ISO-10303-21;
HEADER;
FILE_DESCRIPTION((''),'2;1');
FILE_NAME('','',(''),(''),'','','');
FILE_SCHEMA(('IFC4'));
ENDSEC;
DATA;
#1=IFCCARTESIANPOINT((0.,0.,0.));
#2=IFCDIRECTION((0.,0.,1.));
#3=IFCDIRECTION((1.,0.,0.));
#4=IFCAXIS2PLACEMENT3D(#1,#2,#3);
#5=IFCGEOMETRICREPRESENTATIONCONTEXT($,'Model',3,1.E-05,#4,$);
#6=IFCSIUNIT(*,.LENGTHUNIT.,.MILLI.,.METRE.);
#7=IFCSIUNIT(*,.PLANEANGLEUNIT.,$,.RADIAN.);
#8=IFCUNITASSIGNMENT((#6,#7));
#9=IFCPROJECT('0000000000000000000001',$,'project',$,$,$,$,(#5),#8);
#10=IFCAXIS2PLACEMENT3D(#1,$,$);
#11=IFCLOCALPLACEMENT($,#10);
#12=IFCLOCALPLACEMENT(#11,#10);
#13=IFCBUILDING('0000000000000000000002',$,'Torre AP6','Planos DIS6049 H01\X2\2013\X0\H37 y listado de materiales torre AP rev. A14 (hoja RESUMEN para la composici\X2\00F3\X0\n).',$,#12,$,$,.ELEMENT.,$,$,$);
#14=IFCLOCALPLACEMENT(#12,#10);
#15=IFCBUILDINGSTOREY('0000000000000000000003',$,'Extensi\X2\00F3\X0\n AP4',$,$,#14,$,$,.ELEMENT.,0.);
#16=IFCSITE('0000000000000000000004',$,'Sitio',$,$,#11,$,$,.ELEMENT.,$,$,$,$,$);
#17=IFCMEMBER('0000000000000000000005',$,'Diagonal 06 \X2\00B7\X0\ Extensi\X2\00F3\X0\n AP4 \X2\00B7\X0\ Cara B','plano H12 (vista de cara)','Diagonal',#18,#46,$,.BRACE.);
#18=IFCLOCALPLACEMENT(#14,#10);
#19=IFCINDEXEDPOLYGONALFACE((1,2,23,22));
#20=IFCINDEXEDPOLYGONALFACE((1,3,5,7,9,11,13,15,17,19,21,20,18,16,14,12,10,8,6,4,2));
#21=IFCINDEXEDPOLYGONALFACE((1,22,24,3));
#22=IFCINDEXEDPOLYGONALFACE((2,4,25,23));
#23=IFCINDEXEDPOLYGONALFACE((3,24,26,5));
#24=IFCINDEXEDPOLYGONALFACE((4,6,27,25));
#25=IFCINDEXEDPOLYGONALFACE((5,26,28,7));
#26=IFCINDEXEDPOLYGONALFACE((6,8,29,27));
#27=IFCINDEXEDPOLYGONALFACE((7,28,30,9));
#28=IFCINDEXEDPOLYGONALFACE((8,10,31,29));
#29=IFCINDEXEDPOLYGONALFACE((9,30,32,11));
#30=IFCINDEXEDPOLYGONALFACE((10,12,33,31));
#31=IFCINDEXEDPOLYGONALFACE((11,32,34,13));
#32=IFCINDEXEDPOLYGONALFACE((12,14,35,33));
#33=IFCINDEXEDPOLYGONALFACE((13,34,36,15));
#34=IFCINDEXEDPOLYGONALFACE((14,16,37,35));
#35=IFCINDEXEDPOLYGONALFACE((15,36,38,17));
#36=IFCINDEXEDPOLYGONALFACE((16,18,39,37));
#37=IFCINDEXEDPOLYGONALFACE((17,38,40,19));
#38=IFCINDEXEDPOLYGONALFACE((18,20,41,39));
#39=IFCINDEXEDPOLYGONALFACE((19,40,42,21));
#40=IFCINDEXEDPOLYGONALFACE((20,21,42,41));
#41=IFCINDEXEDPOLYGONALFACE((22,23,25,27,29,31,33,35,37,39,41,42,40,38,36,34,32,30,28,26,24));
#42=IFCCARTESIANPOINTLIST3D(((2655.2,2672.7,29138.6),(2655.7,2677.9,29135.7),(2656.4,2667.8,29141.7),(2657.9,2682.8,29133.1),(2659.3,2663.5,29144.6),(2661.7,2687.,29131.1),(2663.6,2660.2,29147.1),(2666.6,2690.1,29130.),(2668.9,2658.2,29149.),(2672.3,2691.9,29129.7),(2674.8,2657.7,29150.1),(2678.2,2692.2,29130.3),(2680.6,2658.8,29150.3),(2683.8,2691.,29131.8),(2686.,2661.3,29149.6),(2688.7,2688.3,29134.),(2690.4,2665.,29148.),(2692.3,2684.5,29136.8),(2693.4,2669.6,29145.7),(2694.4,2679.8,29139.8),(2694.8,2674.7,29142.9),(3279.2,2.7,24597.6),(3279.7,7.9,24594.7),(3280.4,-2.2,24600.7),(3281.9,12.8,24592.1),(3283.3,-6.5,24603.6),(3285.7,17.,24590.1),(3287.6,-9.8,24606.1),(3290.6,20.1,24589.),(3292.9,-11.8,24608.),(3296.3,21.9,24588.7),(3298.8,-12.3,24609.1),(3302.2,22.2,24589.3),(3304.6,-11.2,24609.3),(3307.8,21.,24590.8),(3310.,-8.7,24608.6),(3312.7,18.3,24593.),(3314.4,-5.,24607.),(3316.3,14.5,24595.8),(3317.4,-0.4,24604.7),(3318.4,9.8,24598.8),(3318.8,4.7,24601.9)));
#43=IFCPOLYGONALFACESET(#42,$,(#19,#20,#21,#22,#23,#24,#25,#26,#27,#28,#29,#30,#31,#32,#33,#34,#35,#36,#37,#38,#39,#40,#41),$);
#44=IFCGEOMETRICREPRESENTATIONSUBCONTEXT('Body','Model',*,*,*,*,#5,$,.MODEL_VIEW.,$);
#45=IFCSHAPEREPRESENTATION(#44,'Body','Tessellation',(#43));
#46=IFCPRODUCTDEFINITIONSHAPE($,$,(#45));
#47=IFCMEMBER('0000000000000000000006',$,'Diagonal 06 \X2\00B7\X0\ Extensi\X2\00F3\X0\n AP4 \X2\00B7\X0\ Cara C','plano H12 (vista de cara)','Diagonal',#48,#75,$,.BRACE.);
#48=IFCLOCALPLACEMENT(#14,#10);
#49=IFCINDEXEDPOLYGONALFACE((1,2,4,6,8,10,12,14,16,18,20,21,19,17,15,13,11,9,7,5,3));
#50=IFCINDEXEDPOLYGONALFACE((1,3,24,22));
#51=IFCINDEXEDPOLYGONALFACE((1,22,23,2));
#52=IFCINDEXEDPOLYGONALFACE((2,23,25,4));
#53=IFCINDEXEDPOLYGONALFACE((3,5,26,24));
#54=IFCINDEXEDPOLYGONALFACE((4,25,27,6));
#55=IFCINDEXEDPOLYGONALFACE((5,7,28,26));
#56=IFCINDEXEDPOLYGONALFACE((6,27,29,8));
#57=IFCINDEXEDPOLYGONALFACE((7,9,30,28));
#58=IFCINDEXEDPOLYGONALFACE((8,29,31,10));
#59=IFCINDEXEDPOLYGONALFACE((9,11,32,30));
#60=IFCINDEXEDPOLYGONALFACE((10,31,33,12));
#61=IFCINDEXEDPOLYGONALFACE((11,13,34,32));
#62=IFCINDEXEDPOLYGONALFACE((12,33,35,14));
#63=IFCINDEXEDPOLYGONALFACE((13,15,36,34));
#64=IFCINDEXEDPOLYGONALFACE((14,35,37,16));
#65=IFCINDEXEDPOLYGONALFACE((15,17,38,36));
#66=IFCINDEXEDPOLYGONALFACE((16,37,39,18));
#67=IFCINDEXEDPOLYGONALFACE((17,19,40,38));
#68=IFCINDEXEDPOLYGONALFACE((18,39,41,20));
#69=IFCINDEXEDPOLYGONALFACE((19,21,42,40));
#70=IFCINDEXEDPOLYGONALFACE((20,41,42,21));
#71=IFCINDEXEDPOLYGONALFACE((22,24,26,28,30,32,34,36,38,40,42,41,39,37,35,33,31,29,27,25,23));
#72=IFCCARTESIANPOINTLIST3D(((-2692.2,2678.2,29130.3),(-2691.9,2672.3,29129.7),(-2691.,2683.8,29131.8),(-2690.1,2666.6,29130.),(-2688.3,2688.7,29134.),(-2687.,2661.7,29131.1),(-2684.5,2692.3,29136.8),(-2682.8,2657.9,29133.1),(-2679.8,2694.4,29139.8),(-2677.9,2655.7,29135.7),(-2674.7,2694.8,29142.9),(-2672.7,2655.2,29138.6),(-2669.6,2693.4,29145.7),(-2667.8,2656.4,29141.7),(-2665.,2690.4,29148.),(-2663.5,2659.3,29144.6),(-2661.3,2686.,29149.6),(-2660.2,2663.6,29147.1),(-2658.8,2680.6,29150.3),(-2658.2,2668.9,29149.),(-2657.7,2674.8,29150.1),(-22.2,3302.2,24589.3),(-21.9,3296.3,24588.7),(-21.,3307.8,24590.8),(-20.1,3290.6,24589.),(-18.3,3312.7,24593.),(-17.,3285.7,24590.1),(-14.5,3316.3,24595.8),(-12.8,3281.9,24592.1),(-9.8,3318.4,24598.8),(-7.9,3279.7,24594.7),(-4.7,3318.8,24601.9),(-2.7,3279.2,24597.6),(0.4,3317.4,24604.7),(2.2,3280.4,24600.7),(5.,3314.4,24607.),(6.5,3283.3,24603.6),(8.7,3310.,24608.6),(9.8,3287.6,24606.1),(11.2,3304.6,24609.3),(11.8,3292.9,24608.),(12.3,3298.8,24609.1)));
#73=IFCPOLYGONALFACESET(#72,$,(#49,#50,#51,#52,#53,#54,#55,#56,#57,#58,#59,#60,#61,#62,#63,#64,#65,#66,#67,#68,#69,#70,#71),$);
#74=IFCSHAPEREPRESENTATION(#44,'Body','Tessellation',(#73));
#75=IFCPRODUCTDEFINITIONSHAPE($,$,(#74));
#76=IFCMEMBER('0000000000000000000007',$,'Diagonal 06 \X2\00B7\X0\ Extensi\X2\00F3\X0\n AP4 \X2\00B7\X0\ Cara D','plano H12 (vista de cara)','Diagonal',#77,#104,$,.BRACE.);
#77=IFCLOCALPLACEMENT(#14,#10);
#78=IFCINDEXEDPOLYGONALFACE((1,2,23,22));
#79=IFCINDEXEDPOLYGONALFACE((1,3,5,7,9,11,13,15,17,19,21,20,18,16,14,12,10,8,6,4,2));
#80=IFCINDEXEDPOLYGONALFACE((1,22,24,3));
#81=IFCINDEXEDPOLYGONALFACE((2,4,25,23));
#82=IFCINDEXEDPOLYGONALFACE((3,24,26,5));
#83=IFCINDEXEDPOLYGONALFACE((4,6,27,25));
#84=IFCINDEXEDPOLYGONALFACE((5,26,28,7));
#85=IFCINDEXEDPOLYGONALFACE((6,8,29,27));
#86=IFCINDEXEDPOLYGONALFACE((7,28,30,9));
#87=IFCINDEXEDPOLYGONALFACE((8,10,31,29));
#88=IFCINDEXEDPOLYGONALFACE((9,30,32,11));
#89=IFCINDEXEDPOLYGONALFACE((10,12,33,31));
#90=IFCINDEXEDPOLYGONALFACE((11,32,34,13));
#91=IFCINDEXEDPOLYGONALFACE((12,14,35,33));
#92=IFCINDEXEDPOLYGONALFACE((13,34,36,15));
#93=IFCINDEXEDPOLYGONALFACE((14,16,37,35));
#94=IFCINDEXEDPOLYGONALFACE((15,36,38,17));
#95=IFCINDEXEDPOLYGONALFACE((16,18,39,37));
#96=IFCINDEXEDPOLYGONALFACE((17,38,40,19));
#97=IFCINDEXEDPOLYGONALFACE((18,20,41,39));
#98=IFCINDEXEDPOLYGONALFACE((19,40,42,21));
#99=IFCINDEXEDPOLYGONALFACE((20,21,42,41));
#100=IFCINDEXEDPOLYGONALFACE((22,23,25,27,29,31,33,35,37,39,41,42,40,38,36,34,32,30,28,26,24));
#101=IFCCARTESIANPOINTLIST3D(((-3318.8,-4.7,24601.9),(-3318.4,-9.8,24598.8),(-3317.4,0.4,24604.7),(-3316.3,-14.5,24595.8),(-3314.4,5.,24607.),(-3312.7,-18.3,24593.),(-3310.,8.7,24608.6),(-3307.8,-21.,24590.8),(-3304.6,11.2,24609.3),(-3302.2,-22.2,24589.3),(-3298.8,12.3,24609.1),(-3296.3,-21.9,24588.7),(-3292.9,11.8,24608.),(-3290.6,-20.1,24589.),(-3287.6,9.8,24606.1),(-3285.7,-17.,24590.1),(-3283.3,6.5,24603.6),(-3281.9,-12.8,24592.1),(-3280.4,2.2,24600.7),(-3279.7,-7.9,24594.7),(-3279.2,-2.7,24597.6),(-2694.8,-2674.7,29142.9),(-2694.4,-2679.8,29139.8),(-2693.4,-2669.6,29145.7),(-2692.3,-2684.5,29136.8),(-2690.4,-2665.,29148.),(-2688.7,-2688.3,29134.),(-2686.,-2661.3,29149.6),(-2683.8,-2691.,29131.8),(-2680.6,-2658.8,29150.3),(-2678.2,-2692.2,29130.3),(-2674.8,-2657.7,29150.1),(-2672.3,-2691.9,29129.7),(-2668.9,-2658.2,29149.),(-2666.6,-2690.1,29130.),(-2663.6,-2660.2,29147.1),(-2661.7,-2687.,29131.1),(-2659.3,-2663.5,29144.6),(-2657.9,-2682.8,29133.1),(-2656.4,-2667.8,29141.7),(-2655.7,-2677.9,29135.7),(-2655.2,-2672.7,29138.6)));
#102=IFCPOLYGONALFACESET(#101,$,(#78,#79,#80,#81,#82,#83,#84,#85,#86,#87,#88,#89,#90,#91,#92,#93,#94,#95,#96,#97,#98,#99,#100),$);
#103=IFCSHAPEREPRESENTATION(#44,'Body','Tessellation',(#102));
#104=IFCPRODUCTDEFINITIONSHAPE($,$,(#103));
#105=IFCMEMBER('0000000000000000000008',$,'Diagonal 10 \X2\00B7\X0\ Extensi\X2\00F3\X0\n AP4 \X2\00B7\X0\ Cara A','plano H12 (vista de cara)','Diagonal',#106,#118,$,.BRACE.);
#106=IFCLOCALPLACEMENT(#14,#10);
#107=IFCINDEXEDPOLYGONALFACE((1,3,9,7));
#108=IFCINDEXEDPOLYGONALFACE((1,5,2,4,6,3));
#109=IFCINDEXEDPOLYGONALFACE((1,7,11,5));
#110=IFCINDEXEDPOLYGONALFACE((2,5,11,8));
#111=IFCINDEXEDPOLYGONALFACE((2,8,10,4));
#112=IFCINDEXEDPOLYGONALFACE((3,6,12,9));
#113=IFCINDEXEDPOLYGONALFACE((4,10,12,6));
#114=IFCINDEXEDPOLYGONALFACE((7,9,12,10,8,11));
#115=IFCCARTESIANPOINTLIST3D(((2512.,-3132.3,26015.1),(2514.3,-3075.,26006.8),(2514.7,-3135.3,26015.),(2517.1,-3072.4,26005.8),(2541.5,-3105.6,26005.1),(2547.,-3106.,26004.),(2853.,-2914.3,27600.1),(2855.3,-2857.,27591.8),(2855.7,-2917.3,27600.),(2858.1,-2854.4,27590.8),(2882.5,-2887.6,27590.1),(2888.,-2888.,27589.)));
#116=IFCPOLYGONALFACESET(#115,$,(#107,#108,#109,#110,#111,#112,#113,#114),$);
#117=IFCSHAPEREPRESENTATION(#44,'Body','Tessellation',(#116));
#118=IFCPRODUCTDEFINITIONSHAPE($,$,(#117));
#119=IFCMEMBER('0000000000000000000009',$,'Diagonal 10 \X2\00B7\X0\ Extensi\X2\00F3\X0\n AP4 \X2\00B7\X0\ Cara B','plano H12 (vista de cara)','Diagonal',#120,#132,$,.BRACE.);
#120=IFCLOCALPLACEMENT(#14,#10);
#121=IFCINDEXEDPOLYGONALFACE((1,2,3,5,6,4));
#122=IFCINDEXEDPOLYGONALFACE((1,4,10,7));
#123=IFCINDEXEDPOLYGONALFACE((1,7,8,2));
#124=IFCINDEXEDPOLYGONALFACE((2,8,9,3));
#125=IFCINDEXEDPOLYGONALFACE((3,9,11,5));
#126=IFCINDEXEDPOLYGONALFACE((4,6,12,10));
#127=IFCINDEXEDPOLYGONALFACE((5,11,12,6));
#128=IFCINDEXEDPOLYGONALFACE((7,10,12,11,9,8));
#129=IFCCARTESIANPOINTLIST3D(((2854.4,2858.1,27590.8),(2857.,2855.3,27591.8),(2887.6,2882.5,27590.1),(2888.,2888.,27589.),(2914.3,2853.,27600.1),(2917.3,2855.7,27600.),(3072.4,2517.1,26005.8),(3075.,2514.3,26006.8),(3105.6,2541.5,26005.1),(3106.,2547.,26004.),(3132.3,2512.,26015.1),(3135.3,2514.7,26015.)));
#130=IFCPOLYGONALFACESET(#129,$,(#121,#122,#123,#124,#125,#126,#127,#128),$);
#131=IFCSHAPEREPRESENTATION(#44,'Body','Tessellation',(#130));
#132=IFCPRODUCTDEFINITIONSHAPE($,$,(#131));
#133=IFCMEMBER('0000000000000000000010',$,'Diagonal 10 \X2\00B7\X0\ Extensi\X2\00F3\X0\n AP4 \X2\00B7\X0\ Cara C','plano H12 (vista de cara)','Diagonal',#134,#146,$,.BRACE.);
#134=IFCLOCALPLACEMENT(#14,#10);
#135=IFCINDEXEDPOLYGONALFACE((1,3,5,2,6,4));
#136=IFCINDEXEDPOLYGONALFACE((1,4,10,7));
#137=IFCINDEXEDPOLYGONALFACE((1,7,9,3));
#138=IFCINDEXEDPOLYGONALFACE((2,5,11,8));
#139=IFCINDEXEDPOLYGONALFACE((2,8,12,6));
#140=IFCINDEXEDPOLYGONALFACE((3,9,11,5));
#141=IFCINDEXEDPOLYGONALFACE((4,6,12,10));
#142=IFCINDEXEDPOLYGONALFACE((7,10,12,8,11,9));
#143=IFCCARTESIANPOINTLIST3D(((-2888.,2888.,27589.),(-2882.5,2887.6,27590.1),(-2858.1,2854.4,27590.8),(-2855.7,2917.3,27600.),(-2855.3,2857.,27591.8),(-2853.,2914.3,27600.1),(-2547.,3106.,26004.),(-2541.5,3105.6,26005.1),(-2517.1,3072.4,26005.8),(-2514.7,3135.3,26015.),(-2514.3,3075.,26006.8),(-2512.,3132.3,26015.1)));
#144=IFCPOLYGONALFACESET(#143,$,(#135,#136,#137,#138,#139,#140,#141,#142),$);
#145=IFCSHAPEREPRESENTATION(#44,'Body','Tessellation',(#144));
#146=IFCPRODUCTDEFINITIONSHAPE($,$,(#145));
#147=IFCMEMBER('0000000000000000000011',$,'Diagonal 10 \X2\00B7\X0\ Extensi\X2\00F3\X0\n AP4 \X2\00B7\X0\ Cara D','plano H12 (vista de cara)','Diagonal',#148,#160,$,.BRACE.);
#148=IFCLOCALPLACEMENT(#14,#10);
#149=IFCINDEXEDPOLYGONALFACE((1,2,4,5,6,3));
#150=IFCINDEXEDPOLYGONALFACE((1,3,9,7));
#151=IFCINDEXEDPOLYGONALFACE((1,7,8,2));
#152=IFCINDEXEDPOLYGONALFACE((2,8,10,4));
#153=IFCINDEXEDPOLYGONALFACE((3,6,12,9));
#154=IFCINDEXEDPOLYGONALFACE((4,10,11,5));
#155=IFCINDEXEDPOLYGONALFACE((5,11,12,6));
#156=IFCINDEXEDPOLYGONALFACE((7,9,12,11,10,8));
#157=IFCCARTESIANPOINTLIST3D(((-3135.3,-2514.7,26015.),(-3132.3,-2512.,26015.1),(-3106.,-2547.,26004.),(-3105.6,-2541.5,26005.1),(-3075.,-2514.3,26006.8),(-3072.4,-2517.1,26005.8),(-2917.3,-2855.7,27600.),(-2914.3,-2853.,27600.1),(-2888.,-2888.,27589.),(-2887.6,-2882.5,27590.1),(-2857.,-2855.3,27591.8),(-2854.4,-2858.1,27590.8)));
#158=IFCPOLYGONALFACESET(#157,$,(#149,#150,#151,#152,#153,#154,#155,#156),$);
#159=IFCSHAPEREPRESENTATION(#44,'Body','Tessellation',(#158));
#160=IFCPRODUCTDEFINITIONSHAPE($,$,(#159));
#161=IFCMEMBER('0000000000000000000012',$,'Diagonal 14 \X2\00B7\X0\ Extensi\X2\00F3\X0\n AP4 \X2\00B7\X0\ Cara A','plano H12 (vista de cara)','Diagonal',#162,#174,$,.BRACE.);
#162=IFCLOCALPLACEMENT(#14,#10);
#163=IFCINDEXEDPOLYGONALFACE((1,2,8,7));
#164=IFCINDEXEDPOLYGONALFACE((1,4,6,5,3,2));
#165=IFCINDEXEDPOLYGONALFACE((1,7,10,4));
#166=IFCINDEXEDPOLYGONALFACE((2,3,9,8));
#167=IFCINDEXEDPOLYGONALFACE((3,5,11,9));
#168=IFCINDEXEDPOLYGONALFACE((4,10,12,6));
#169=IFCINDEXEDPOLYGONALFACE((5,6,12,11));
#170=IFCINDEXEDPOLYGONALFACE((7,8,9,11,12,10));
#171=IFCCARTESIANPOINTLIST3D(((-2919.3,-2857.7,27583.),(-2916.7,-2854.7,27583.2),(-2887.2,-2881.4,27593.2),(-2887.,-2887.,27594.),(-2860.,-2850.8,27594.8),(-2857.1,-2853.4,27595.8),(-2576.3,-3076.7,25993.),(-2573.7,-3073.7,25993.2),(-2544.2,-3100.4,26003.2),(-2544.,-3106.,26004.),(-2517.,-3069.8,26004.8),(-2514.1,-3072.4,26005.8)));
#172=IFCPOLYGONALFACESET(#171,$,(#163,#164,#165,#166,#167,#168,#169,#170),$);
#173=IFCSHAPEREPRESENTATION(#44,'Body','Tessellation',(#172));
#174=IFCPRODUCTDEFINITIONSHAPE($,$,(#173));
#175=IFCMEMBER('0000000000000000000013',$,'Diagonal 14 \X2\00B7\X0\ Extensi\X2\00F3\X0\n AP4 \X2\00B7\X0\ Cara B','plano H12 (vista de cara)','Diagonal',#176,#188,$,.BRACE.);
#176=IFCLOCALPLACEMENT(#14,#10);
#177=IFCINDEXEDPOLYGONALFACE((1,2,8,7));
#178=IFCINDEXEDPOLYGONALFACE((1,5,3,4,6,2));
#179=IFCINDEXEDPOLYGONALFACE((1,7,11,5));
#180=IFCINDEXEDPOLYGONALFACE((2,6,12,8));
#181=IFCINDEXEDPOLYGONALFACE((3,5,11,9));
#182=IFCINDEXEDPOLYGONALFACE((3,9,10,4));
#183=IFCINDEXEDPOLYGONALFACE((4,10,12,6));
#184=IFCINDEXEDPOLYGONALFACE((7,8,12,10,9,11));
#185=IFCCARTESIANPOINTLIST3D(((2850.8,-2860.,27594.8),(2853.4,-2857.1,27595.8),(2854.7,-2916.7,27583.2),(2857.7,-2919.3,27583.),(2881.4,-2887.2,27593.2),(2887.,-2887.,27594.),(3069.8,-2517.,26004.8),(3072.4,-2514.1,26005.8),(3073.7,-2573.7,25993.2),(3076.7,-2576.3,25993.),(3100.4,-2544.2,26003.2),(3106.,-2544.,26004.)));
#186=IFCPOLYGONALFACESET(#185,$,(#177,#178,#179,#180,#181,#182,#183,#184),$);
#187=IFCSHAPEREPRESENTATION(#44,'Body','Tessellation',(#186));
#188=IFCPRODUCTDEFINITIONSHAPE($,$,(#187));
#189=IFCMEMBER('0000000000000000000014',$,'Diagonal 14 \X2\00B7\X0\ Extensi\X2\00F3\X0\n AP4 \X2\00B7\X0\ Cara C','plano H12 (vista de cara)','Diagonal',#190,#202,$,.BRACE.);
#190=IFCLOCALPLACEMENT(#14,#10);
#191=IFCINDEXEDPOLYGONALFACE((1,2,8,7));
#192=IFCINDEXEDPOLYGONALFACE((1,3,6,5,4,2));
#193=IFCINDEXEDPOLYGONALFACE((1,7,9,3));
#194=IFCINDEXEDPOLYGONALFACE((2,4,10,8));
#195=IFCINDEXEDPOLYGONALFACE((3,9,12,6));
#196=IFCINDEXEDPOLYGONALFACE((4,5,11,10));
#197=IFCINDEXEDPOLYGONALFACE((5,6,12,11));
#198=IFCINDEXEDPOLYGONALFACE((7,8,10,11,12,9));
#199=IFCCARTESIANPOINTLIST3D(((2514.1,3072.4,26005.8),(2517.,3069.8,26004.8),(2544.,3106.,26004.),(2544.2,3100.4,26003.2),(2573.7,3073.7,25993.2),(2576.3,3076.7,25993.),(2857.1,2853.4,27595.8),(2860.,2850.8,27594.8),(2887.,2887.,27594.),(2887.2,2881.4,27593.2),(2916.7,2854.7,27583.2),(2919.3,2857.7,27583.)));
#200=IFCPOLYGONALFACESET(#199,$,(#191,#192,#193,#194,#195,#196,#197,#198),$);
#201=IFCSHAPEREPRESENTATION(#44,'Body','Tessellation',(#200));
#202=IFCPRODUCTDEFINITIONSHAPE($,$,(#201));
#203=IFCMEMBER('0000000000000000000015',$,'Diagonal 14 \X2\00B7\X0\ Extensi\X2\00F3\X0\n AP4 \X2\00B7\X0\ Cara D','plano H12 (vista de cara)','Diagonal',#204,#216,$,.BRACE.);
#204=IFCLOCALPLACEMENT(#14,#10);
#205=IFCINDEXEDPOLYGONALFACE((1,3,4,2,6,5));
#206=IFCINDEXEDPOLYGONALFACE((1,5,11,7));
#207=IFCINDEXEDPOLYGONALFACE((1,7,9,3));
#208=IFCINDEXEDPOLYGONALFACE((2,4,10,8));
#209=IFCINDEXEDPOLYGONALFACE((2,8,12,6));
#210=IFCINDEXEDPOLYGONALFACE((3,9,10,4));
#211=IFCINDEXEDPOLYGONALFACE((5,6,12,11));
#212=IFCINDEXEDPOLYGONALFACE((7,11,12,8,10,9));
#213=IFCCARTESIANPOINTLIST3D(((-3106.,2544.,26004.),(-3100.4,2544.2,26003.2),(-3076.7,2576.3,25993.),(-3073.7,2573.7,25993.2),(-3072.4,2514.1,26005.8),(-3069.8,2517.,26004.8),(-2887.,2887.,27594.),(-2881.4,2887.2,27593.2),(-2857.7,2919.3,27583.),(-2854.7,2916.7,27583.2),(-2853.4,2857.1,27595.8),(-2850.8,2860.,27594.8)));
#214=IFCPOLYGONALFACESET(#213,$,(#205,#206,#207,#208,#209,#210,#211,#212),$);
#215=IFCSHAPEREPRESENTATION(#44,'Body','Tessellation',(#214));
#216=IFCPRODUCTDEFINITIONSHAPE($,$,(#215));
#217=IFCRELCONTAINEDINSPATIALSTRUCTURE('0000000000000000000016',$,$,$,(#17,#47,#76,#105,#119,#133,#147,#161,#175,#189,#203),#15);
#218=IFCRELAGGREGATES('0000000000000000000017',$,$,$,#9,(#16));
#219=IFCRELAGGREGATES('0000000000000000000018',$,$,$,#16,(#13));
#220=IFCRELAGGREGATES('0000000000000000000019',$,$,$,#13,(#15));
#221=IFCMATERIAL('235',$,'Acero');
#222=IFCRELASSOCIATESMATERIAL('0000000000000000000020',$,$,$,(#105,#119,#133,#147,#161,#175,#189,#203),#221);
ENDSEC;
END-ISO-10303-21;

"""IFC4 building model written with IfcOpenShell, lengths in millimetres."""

from ifc_helpers import new_model, si_unit, frame, frame_2d, origin, origin_with_axes, place, context, subcontext, project, spatial, circle, l_section, extrude, material, element, save


model = new_model("IFC4")

# Units and contexts
model_context = context("Model", 3, precision=1e-05, world=origin_with_axes())
body_context = subcontext(model_context, "Body", "Model", "MODEL_VIEW")
ifc_project = project(units=[si_unit("LENGTHUNIT", "METRE", prefix="MILLI"), si_unit("PLANEANGLEUNIT", "RADIAN")], contexts=[model_context])

# Site, building, storey
site_placement = place(None, origin())
site = spatial("IfcSite", under=ifc_project, at=site_placement, Name="Sitio", CompositionType="ELEMENT")
building_placement = place(site_placement, origin())
building = spatial("IfcBuilding", under=site, at=building_placement, Name="Torre AP6", Description="Planos DIS6049 H01–H37 y listado de materiales torre AP rev. A14 (hoja RESUMEN para la composición).", CompositionType="ELEMENT")
storey_placement = place(building_placement, origin())
storey = spatial("IfcBuildingStorey", under=building, at=storey_placement, Name="Extensión AP4", CompositionType="ELEMENT", Elevation=0.0)

# Members
ifc_material_1 = material(Name="235", Category="Acero")
for number, where, z_axis, x_axis, name in (
    (1, (3299.0, 5.0, 24599.0), (-0.117633, 0.503335, 0.856047), (-0.928538, -0.361399, 0.0849), "Diagonal 06 · Extensión AP4 · Cara B"),
    (2, (-5.0, 3299.0, 24599.0), (-0.503335, -0.117633, 0.856047), (0.361399, -0.928538, 0.0849), "Diagonal 06 · Extensión AP4 · Cara C"),
    (3, (-3299.0, -5.0, 24599.0), (0.117633, -0.503335, 0.856047), (0.928538, 0.361399, 0.0849), "Diagonal 06 · Extensión AP4 · Cara D"),
):
    element("IfcMember", number, at=place(storey_placement, frame(where, z_axis=z_axis, x_axis=x_axis)), inside=storey, Name=name, Description="plano H12 (vista de cara)", ObjectType="Diagonal", PredefinedType="BRACE", context=body_context, shape_type="SweptSolid", body=[
        extrude(circle(Radius=20.0), None, (0.0, 0.0, 1.0), 5304.6),
    ])
for number, where, z_axis, x_axis, name in (
    (4, (2547.0, -3106.0, 26004.0), (0.208453, 0.133263, 0.968911), (-0.663676, 0.746947, 0.04005), "Diagonal 10 · Extensión AP4 · Cara A"),
    (5, (3106.0, 2547.0, 26004.0), (-0.133263, 0.208453, 0.968911), (-0.746947, -0.663676, 0.04005), "Diagonal 10 · Extensión AP4 · Cara B"),
    (6, (-2547.0, 3106.0, 26004.0), (-0.208453, -0.133263, 0.968911), (0.663676, -0.746947, 0.04005), "Diagonal 10 · Extensión AP4 · Cara C"),
    (7, (-3106.0, -2547.0, 26004.0), (0.133263, -0.208453, 0.968911), (0.746947, 0.663676, 0.04005), "Diagonal 10 · Extensión AP4 · Cara D"),
):
    element("IfcMember", number, at=place(storey_placement, frame(where, z_axis=z_axis, x_axis=x_axis)), inside=storey, material=ifc_material_1, Name=name, Description="plano H12 (vista de cara)", ObjectType="Diagonal", PredefinedType="BRACE", context=body_context, shape_type="SweptSolid", body=[
        extrude(l_section(Depth=45.0, Width=45.0, Thickness=4.0, at=frame_2d((22.5, 22.5))), None, (0.0, 0.0, 1.0), 1635.9),
    ])
for number, where, z_axis, x_axis, name in (
    (8, (-2544.0, -3106.0, 26004.0), (-0.208987, 0.133435, 0.968772), (0.663414, 0.747172, 0.040202), "Diagonal 14 · Extensión AP4 · Cara A"),
    (9, (3106.0, -2544.0, 26004.0), (-0.133435, -0.208987, 0.968772), (-0.747172, 0.663414, 0.040202), "Diagonal 14 · Extensión AP4 · Cara B"),
    (10, (2544.0, 3106.0, 26004.0), (0.208987, -0.133435, 0.968772), (-0.663414, -0.747172, 0.040202), "Diagonal 14 · Extensión AP4 · Cara C"),
    (11, (-3106.0, 2544.0, 26004.0), (0.133435, 0.208987, 0.968772), (0.747172, -0.663414, 0.040202), "Diagonal 14 · Extensión AP4 · Cara D"),
):
    element("IfcMember", number, at=place(storey_placement, frame(where, z_axis=z_axis, x_axis=x_axis)), inside=storey, material=ifc_material_1, Name=name, Description="plano H12 (vista de cara)", ObjectType="Diagonal", PredefinedType="BRACE", context=body_context, shape_type="SweptSolid", body=[
        extrude(l_section(Depth=45.0, Width=45.0, Thickness=4.0, at=frame_2d((22.5, 22.5))), None, (0.0, 0.0, 1.0), 1641.3),
    ])

save(model, "model.ifc")
